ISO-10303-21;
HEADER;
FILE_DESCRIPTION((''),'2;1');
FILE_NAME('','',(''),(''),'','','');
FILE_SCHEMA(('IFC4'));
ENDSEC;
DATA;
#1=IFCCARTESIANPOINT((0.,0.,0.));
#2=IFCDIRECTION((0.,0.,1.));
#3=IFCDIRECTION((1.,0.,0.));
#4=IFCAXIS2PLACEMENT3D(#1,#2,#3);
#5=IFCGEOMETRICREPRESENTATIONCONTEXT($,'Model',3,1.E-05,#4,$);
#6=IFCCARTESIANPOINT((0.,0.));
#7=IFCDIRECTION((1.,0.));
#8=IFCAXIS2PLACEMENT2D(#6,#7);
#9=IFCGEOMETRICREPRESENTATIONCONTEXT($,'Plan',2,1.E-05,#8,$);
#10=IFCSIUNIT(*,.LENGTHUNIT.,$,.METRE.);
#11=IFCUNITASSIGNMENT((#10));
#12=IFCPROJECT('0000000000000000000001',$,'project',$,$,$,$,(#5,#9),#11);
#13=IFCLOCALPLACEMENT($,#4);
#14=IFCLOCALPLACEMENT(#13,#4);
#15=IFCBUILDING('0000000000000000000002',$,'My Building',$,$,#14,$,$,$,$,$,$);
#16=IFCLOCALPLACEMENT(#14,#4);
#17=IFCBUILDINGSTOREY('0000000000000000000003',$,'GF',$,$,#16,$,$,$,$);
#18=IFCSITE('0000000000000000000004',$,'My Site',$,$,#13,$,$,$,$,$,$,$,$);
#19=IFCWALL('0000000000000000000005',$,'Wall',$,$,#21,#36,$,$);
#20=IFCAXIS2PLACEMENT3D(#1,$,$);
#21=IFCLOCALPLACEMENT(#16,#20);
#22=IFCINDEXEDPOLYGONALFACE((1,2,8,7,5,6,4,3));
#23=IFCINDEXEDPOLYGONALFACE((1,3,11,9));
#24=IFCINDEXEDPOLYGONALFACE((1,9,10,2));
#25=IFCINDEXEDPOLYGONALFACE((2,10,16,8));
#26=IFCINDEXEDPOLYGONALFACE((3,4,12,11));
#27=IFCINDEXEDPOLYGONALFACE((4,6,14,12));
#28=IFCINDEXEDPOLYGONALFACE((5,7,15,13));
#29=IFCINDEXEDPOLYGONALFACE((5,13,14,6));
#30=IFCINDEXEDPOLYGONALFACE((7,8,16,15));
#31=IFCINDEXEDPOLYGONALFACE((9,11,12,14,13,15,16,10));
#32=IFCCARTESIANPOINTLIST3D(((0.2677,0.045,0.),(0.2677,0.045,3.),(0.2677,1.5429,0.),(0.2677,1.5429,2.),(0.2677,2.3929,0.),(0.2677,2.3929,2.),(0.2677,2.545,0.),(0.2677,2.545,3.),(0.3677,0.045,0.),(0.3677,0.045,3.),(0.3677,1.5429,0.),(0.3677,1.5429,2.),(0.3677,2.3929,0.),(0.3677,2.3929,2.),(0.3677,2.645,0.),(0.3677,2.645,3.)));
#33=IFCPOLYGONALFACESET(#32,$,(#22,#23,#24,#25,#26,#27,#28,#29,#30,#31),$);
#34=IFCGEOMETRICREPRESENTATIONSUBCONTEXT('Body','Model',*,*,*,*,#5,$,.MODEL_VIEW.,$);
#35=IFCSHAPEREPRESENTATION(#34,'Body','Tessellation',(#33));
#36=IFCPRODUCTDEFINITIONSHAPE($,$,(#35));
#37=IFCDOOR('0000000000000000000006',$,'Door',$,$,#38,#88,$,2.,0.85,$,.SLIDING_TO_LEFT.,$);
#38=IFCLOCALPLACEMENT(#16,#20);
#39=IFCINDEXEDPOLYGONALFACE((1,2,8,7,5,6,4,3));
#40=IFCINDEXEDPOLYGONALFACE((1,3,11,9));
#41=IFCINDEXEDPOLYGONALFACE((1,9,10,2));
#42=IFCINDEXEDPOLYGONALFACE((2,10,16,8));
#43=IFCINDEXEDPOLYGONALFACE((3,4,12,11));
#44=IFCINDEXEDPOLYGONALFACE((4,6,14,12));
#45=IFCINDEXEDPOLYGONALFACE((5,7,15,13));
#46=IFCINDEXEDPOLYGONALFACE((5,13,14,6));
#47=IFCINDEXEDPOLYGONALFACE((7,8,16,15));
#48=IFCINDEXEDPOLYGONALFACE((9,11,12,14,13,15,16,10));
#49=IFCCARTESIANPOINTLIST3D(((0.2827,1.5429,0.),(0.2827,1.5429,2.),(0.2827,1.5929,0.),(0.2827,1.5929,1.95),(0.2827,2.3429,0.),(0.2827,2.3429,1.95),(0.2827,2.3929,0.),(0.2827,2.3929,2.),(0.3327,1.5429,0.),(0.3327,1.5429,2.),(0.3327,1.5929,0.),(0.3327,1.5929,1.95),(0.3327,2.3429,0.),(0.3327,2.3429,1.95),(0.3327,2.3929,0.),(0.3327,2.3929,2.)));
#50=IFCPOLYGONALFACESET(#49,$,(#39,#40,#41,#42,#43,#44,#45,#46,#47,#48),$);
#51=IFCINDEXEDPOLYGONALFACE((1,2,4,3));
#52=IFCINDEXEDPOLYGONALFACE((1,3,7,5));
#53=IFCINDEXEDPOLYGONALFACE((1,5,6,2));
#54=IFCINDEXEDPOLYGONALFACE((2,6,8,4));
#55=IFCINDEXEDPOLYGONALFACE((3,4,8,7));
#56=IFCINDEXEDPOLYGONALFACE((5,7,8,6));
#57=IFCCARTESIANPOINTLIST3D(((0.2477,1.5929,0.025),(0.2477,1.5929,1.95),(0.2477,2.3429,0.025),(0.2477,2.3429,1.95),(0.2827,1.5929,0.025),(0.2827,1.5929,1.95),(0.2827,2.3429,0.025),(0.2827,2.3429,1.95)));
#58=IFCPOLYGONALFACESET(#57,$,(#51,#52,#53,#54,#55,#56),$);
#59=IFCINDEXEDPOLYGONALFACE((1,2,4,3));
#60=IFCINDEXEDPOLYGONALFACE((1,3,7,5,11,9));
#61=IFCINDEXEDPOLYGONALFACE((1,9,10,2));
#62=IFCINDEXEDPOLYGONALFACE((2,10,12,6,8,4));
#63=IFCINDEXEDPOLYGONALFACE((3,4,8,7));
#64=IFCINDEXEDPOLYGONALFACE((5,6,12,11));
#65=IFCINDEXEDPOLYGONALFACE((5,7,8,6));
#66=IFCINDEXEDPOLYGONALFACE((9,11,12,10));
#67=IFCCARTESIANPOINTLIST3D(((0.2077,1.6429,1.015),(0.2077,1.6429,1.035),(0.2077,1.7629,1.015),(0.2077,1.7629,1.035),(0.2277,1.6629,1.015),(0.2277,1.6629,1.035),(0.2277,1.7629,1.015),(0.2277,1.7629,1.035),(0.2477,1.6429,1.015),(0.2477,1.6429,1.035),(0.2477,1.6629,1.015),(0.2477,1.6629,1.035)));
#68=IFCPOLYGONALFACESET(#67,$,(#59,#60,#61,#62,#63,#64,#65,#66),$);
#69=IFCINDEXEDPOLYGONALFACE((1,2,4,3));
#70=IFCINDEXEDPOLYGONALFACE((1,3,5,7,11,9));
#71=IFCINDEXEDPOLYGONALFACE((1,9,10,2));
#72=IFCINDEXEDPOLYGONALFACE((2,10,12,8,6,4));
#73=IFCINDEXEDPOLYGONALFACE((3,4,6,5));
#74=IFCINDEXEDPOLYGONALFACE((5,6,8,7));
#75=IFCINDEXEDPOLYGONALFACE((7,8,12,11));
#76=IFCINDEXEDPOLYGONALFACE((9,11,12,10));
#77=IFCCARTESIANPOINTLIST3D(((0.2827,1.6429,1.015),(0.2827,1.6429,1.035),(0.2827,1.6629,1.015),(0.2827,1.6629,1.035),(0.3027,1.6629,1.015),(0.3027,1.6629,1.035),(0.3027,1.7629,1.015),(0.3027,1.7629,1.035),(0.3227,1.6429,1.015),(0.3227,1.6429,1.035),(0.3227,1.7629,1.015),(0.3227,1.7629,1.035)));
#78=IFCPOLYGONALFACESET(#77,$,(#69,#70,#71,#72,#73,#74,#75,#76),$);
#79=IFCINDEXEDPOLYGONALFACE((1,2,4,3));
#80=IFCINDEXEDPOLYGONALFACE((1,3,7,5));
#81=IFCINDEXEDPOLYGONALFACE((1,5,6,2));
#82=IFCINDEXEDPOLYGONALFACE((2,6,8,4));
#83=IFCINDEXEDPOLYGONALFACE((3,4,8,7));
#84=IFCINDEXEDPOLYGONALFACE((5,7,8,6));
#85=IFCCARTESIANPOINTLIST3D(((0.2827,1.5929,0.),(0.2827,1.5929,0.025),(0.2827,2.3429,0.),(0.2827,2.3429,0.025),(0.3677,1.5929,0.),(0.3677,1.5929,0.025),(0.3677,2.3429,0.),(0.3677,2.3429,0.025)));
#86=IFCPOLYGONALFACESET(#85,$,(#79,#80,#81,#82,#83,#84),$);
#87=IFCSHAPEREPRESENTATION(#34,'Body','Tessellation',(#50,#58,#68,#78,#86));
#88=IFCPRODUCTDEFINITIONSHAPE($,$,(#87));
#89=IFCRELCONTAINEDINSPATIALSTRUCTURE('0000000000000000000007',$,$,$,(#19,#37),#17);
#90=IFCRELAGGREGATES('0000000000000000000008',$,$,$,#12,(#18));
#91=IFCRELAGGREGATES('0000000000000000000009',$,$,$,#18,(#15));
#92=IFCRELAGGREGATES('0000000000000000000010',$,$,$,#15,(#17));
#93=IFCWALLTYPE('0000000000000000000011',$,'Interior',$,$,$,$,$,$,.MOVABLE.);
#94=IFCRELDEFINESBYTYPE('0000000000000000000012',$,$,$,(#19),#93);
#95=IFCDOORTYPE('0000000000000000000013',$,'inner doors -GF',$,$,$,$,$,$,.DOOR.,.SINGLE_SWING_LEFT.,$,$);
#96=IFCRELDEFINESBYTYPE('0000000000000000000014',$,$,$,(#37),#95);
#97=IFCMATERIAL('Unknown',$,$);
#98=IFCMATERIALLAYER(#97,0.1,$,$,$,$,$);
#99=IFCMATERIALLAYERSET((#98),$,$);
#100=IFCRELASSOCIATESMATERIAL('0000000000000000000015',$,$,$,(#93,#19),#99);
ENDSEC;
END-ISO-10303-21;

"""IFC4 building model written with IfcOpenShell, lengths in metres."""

from ifc_helpers import new_model, entity, si_unit, frame, origin_with_axes, origin_2d_with_axis, place, context, subcontext, project, spatial, line, indexed_curve, outline, extrude, shape, source, transform, mapped, material, layer, layer_set, layer_usage, type_object, type_shapes, element, fill, save


model = new_model("IFC4")

# Units and contexts
model_context = context("Model", 3, precision=1e-05, world=origin_with_axes())
plan_context = context("Plan", 2, precision=1e-05, world=origin_2d_with_axis())
body_context_1 = subcontext(model_context, "Body", "Model", "MODEL_VIEW")
body_context_2 = subcontext(plan_context, "Body", "Plan", "PLAN_VIEW")
ifc_project = project(units=[si_unit("LENGTHUNIT", "METRE")], contexts=[model_context, plan_context])

# Site, building, storey
site_placement = place(None, origin_with_axes())
site = spatial("IfcSite", under=ifc_project, at=site_placement, Name="My Site")
building_placement = place(site_placement, origin_with_axes())
building = spatial("IfcBuilding", under=site, at=building_placement, Name="My Building")
storey_placement = place(building_placement, origin_with_axes())
storey = spatial("IfcBuildingStorey", under=building, at=storey_placement, Name="GF")

# Shared definitions
ifc_material = material(Name="Unknown")

# Wall, opening, door
ifc_layer_1 = layer(ifc_material, 0.1)
ifc_layer_set_1 = layer_set([ifc_layer_1])
ifc_layer_usage_1 = layer_usage(ifc_layer_set_1, "AXIS2", "POSITIVE", 0.0)
wall_type_1 = type_object("IfcWallType", Name="Interior", PredefinedType="MOVABLE", material=ifc_layer_set_1)
wall_1_placement = place(storey_placement, frame((0.3677, 0.045, 0.0), z_axis=(0.0, 0.0, 1.0), x_axis=(0.0, 1.0, 0.0)))
wall_1 = element("IfcWall", 1, at=wall_1_placement, inside=storey, type_object=wall_type_1, material=ifc_layer_usage_1, Name="Wall", context=body_context_1, shape_type="SweptSolid", body=[
    extrude(outline(indexed_curve([(0.0, 0.0), (0.0, 0.1), (2.5, 0.1), (2.6, 0.0)], segments=[line(1, 2, 3, 4, 1)])), origin_with_axes(), (0.0, 0.0, 1.0), 3.0),
])
shared_shape_1 = source(origin_with_axes(), body_context_1, "Body", "SweptSolid", [
    extrude(outline(indexed_curve([(0.0, 0.0), (0.85, 0.0), (0.85, 2.0), (0.0, 2.0)], segments=[line(1, 2, 3, 4, 1)])), frame((0.0, -0.6, 0.0), z_axis=(0.0, -1.0, 0.0), x_axis=(1.0, 0.0, 0.0)), (0.0, 0.0, -1.0), 1.2),
])
opening_1_placement = place(wall_1_placement, frame((2.3479, 0.1, 0.0), z_axis=(0.0, 0.0, 1.0), x_axis=(-1.0, 0.0, 0.0)))
opening_1 = element("IfcOpeningElement", 2, at=opening_1_placement, cuts=wall_1, PredefinedType="OPENING", context=body_context_1, shape_type="MappedRepresentation", body=[
    mapped(shared_shape_1, transform((0.0, 0.0, 0.0), x_axis=(1.0, 0.0, 0.0), y_axis=(0.0, 1.0, 0.0), z_axis=(0.0, 0.0, 1.0), scale=1.0)),
])
door_type_1 = type_object("IfcDoorType", Name="inner doors -GF", OperationType="SINGLE_SWING_LEFT", PredefinedType="DOOR")
shared_shape_2 = source(origin_with_axes(), body_context_1, "Body", "SweptSolid", [
    extrude(outline(indexed_curve([(0.0, 0.0), (0.0, 2.0), (0.85, 2.0), (0.85, 0.0), (0.8, 0.0), (0.8, 1.95), (0.05, 1.95), (0.05, 0.0)], segments=[line(1, 2, 3, 4, 5, 6, 7, 8, 1)])), frame((0.0, 0.0, 0.0), z_axis=(0.0, -1.0, 0.0), x_axis=(1.0, 0.0, 0.0)), (0.0, 0.0, -1.0), 0.05),
    extrude(outline(indexed_curve([(0.0, 0.0), (0.75, 0.0), (0.75, 0.035), (0.0, 0.035)], segments=[line(1, 2, 3, 4, 1)])), frame((0.05, -0.035, 0.025), z_axis=(0.0, 0.0, 1.0), x_axis=(1.0, 0.0, 0.0)), (0.0, 0.0, 1.0), 1.925),
    extrude(outline(indexed_curve([(0.0, 0.0), (0.0, -0.04), (-0.12, -0.04), (-0.12, -0.02), (-0.02, -0.02), (-0.02, 0.0)], segments=[line(1, 2, 3, 4, 5, 6, 1)])), frame((0.75, -0.035, 1.015), z_axis=(0.0, 0.0, 1.0), x_axis=(1.0, 0.0, 0.0)), (0.0, 0.0, 1.0), 0.02),
    extrude(outline(indexed_curve([(0.0, 0.0), (0.0, 0.04), (-0.12, 0.04), (-0.12, 0.02), (-0.02, 0.02), (-0.02, 0.0)], segments=[line(1, 2, 3, 4, 5, 6, 1)])), frame((0.75, 0.0, 1.015), z_axis=(0.0, 0.0, 1.0), x_axis=(1.0, 0.0, 0.0)), (0.0, 0.0, 1.0), 0.02),
    extrude(outline(indexed_curve([(0.0, 0.0), (0.75, 0.0), (0.75, 0.085), (0.0, 0.085)], segments=[line(1, 2, 3, 4, 1)])), frame((0.05, 0.0, 0.0), z_axis=(0.0, 0.0, 1.0), x_axis=(1.0, 0.0, 0.0)), (0.0, 0.0, 1.0), 0.025),
])
shared_shape_3 = source(origin_with_axes(), body_context_2, "Body", "Curve2D", [
    entity("IfcIndexedPolyCurve", entity("IfcCartesianPointList2D", [[0.0, 0.0], [0.05, 0.0], [0.05, 0.05], [0.0, 0.05]]), [entity("IfcLineIndex", [1, 2, 3, 4, 1])]),
    entity("IfcIndexedPolyCurve", entity("IfcCartesianPointList2D", [[0.85, 0.0], [0.8, 0.0], [0.8, 0.05], [0.85, 0.05]]), [entity("IfcLineIndex", [1, 2, 3, 4, 1])]),
    entity("IfcIndexedPolyCurve", entity("IfcCartesianPointList2D", [[-0.325, -0.035], [0.425, -0.035], [0.425, 0.0], [-0.325, 0.0]]), [entity("IfcLineIndex", [1, 2, 3, 4, 1])]),
])
type_shapes(door_type_1, [shared_shape_2, shared_shape_3])
door_1_placement = place(opening_1_placement, frame((0.0, 0.015, 0.0), z_axis=(0.0, 0.0, 1.0), x_axis=(1.0, 0.0, 0.0)))
door_1 = element("IfcDoor", 3, at=door_1_placement, inside=storey, type_object=door_type_1, Name="Door", OperationType="SLIDING_TO_LEFT", OverallHeight=2.0, OverallWidth=0.85, shapes=[
    shape(body_context_1, "Body", "MappedRepresentation", [mapped(shared_shape_2, transform((0.0, 0.0, 0.0), x_axis=(1.0, 0.0, 0.0), y_axis=(0.0, 1.0, 0.0), z_axis=(0.0, 0.0, 1.0), scale=1.0))]),
    shape(body_context_2, "Body", "MappedRepresentation", [mapped(shared_shape_3, transform((0.0, 0.0, 0.0), x_axis=(1.0, 0.0, 0.0), y_axis=(0.0, 1.0, 0.0), z_axis=(0.0, 0.0, 1.0), scale=1.0))]),
])
fill(opening_1, door_1)

save(model, "model.ifc")
